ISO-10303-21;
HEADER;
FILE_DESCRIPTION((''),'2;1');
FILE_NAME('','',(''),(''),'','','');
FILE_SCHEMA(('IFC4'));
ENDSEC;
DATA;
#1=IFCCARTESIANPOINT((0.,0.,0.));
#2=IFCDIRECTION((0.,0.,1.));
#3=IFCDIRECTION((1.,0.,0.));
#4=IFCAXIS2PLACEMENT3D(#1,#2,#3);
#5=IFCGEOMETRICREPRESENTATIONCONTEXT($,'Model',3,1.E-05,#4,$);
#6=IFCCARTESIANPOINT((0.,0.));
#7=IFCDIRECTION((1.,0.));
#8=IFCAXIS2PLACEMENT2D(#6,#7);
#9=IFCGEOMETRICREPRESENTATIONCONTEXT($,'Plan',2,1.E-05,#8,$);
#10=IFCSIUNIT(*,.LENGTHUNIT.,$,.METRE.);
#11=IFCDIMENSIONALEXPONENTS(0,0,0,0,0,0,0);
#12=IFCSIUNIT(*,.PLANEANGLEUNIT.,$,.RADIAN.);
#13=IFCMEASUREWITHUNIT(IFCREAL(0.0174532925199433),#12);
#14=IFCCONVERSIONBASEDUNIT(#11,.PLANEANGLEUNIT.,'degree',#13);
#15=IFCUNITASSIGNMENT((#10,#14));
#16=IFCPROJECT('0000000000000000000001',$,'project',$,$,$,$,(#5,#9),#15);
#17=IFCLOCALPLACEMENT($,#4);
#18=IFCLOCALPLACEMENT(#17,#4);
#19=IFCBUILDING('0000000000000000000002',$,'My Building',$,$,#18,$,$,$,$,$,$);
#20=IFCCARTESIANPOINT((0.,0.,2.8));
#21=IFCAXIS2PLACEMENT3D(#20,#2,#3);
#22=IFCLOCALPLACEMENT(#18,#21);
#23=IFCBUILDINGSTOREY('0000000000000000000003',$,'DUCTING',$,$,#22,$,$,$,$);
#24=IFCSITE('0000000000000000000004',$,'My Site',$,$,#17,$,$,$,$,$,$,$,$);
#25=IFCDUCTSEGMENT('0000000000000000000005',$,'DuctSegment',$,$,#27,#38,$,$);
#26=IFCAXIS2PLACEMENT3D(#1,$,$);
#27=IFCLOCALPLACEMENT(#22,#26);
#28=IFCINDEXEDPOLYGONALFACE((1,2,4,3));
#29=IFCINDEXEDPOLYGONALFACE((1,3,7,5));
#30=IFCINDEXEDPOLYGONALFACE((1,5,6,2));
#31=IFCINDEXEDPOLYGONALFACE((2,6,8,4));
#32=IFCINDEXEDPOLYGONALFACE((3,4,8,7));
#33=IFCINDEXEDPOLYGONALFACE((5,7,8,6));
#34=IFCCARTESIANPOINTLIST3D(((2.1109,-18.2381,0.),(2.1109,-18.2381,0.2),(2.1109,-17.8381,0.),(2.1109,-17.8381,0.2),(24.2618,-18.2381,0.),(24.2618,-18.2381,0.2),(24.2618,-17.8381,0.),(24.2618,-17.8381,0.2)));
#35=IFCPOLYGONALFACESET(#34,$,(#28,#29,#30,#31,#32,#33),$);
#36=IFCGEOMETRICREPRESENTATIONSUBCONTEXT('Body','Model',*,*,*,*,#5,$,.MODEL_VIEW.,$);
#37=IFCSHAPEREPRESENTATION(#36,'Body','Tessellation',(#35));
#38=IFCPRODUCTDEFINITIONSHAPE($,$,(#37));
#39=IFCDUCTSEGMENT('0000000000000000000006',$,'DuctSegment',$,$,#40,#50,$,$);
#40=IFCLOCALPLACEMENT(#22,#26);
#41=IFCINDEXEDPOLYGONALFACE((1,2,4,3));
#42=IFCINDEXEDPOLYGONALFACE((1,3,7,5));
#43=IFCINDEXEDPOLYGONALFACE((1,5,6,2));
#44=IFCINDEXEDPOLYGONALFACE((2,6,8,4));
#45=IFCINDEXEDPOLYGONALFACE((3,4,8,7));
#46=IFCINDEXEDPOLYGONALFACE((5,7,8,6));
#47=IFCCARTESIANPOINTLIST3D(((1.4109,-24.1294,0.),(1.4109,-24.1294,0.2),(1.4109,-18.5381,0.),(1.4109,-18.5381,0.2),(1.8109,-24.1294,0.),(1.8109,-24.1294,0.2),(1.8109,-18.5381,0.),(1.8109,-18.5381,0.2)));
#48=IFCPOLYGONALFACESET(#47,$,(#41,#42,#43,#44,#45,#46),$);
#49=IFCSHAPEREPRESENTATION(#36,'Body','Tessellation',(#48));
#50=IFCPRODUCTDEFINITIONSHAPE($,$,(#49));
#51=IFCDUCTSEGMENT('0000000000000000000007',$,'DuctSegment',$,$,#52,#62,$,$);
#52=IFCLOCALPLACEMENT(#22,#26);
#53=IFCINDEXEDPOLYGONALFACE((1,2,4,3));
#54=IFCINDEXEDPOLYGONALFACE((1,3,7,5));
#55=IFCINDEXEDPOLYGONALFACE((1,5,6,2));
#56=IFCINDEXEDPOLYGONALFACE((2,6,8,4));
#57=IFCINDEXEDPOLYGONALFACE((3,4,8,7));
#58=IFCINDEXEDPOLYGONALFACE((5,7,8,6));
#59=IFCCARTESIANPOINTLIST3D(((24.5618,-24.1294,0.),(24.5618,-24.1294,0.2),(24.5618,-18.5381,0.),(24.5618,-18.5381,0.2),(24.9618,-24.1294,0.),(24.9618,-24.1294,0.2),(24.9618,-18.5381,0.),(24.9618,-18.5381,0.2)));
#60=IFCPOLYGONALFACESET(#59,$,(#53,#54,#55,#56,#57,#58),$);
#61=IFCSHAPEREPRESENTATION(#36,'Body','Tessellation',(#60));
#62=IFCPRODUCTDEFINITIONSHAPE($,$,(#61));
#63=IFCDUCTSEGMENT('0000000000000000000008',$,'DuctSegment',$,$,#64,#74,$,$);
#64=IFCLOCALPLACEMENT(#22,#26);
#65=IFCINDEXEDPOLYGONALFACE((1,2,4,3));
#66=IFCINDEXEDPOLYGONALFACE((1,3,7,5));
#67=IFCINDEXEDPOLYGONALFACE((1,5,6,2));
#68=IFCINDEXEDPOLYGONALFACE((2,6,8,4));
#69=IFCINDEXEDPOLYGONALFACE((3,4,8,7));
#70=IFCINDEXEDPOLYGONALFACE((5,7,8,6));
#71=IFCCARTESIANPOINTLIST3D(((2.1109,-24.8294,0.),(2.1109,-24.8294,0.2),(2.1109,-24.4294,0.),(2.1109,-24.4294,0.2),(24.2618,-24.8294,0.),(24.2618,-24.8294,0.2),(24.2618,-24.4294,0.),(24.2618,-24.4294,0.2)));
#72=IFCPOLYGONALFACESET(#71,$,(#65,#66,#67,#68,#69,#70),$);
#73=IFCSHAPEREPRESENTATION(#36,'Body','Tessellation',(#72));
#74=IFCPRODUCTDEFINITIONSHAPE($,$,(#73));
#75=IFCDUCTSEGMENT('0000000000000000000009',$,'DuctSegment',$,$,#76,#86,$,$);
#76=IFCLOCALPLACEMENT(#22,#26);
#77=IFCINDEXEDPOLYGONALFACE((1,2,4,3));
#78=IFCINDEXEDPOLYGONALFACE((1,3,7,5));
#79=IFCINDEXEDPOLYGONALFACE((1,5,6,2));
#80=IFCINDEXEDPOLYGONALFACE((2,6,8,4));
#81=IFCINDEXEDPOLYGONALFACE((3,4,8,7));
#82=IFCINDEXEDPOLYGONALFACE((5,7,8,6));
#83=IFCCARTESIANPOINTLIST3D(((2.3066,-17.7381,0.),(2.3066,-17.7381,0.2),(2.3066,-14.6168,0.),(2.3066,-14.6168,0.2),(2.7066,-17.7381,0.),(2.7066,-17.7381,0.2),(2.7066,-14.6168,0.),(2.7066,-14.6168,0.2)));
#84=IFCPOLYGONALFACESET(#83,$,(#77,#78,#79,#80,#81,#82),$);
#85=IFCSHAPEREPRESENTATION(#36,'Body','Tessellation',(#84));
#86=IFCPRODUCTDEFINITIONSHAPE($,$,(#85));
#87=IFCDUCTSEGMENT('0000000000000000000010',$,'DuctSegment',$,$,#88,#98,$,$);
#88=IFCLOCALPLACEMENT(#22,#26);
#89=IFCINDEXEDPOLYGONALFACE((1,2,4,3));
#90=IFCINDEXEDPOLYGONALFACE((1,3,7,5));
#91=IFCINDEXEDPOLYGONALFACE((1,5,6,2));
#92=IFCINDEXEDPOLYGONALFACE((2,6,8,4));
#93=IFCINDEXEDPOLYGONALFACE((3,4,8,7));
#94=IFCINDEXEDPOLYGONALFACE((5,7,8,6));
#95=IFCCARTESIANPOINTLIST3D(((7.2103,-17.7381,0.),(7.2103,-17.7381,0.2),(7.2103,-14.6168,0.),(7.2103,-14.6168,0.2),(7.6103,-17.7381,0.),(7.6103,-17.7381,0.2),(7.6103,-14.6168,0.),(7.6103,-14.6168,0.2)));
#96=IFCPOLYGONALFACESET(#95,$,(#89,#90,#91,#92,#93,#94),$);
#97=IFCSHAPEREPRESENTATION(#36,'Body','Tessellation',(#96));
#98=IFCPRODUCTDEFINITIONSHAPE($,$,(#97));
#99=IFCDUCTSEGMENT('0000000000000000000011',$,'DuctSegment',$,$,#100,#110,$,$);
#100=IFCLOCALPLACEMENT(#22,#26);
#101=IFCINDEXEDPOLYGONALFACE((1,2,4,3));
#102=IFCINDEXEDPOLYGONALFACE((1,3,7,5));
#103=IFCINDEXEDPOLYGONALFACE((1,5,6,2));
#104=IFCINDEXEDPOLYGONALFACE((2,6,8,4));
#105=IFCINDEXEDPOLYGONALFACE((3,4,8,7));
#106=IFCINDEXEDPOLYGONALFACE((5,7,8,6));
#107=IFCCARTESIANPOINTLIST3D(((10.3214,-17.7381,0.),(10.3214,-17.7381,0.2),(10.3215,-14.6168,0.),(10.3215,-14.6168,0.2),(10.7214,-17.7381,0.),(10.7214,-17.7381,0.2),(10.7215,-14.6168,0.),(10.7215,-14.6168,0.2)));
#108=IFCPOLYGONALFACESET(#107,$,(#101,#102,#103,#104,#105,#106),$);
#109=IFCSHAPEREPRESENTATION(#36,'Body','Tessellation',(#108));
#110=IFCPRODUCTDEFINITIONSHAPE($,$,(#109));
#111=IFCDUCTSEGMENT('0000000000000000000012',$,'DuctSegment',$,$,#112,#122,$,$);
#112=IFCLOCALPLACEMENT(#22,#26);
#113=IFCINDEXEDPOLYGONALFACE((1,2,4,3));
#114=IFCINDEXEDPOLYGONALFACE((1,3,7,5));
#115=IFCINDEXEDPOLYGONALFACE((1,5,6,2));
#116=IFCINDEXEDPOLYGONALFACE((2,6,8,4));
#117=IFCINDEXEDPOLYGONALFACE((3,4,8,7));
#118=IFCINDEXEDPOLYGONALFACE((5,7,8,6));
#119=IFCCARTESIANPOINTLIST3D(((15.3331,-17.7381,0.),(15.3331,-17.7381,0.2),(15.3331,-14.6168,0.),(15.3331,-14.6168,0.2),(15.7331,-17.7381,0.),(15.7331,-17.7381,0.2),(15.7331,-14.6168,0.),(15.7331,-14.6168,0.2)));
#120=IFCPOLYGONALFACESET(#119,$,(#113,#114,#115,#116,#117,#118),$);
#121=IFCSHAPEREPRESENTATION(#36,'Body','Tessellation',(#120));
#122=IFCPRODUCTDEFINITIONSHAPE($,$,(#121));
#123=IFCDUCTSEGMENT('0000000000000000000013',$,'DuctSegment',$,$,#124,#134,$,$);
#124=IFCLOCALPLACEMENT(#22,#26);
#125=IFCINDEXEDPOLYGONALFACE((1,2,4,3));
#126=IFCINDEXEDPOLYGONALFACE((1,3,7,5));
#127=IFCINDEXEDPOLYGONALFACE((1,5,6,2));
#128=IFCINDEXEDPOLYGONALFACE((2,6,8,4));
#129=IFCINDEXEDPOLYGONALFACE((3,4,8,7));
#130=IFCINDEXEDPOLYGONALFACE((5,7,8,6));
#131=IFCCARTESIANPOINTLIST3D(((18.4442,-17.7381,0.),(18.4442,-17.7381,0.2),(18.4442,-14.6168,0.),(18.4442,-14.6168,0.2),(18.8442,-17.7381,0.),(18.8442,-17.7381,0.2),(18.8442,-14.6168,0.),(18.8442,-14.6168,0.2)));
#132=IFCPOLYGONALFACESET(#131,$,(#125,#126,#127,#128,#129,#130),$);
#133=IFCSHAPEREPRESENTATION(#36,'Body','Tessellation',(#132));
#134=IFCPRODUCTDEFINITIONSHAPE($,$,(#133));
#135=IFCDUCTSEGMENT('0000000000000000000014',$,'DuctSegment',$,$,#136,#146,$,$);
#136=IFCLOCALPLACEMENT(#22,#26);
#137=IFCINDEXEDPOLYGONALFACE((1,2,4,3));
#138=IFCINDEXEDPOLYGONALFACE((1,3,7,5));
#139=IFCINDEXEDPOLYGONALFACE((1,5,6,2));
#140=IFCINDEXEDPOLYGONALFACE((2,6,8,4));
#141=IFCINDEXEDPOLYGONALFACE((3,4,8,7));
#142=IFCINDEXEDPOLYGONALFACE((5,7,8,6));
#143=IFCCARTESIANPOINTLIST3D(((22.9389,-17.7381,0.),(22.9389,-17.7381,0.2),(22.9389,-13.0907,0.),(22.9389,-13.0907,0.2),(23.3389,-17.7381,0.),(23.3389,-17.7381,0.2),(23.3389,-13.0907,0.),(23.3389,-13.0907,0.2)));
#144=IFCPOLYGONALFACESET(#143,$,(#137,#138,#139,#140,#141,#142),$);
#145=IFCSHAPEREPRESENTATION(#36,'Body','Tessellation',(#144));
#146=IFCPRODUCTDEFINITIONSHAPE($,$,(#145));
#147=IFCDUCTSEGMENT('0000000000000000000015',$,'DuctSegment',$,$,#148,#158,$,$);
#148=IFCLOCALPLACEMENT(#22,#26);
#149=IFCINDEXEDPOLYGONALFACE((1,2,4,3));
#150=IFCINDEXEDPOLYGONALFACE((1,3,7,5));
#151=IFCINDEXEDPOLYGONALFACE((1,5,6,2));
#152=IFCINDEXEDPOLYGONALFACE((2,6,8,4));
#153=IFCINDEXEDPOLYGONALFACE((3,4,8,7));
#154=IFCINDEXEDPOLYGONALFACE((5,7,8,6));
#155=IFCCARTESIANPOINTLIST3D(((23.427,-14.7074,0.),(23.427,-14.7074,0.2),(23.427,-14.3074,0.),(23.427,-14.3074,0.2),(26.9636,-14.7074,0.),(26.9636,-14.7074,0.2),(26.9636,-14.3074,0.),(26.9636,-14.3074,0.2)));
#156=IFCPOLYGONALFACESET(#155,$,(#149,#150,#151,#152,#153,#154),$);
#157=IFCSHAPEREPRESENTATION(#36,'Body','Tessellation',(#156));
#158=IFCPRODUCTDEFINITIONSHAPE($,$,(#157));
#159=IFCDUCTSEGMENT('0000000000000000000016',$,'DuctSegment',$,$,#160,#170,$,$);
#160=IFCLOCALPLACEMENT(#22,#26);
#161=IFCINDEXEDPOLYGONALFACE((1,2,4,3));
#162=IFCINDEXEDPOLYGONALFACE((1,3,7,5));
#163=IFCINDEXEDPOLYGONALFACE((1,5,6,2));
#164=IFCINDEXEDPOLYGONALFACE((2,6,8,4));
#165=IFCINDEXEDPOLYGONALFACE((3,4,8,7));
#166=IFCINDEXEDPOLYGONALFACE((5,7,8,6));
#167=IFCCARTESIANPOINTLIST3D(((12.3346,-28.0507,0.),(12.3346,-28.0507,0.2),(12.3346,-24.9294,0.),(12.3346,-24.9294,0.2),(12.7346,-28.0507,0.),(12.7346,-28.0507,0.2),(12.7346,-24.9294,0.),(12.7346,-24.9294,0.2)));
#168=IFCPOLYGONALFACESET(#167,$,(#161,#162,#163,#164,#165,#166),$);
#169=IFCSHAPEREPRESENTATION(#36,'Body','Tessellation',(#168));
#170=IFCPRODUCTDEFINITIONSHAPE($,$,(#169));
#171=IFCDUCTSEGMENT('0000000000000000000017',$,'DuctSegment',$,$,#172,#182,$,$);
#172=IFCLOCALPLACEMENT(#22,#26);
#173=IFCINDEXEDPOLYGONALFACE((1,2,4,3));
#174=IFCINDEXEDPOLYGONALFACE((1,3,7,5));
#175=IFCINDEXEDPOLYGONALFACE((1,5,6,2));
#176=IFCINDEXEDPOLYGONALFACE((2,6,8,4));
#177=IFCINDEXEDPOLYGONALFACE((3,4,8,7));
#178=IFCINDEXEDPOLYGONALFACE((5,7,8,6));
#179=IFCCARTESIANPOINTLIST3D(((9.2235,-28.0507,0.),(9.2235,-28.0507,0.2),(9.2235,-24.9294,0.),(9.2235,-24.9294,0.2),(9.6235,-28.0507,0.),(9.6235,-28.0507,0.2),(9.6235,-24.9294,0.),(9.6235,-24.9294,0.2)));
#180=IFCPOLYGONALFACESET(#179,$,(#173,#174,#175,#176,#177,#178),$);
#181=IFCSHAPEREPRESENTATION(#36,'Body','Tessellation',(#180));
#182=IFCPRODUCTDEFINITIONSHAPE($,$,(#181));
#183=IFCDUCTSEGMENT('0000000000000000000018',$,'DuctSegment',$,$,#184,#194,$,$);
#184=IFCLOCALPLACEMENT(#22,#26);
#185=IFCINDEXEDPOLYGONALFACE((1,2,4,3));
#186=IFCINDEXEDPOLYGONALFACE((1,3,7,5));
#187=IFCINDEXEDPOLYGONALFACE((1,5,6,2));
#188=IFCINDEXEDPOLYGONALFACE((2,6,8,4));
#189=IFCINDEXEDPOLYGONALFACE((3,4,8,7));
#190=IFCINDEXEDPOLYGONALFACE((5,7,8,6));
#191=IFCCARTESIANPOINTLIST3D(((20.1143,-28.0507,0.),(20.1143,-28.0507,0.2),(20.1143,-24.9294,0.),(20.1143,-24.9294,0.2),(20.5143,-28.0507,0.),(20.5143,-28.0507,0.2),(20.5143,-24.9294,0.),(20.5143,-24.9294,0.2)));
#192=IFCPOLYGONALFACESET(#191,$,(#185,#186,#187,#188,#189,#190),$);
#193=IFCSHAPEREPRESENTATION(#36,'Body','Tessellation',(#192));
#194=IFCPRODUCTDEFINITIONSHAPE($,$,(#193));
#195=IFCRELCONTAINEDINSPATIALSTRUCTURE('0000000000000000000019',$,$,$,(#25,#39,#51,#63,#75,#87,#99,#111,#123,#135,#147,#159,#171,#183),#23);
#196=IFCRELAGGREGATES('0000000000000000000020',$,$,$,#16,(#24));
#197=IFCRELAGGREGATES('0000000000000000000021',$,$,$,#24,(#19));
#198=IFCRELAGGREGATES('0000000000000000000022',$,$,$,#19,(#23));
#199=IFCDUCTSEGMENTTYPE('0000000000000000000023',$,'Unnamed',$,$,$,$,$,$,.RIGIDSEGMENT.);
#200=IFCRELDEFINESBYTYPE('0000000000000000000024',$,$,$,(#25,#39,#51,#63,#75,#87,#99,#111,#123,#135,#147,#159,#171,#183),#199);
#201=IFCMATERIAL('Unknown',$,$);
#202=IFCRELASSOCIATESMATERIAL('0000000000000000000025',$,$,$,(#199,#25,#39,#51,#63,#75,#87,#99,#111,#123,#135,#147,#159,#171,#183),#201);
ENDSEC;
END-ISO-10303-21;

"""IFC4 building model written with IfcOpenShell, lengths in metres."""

from ifc_helpers import new_model, entity, si_unit, converted_unit, frame, origin_with_axes, origin_2d_with_axis, place, context, subcontext, project, spatial, rectangle, extrude, material, material_profile, profile_set, profile_usage, type_object, element, save


model = new_model("IFC4")

# Units and contexts
model_context = context("Model", 3, precision=1e-05, world=origin_with_axes())
plan_context = context("Plan", 2, precision=1e-05, world=origin_2d_with_axis())
body_context = subcontext(model_context, "Body", "Model", "MODEL_VIEW")
ifc_project = project(units=[si_unit("LENGTHUNIT", "METRE"), converted_unit("PLANEANGLEUNIT", "degree", entity("IfcReal", 0.0174532925199433), si_unit("PLANEANGLEUNIT", "RADIAN"), dimensions=[0, 0, 0, 0, 0, 0, 0])], contexts=[model_context, plan_context])

# Site, building, storey
site_placement = place(None, origin_with_axes())
site = spatial("IfcSite", under=ifc_project, at=site_placement, Name="My Site")
building_placement = place(site_placement, origin_with_axes())
building = spatial("IfcBuilding", under=site, at=building_placement, Name="My Building")
storey_placement = place(building_placement, frame((0.0, 0.0, 2.8), z_axis=(0.0, 0.0, 1.0), x_axis=(1.0, 0.0, 0.0)))
storey = spatial("IfcBuildingStorey", under=building, at=storey_placement, Name="DUCTING")

# Duct segments
ifc_material = material(Name="Unknown")
ifc_material_profile_1 = material_profile(ifc_material, rectangle(XDim=0.4, YDim=0.2))
ifc_profile_set_1 = profile_set([ifc_material_profile_1])
ifc_profile_usage_1 = profile_usage(ifc_profile_set_1, cardinal=5)
duct_segment_type = type_object("IfcDuctSegmentType", Name="Unnamed", PredefinedType="RIGIDSEGMENT", material=ifc_profile_set_1)
duct_segment_1_placement = place(storey_placement, frame((2.1109, -18.0381, 0.1), z_axis=(1.0, 0.0, 0.0), x_axis=(0.0, 1.0, 0.0)))
element("IfcDuctSegment", 1, at=duct_segment_1_placement, inside=storey, type_object=duct_segment_type, material=ifc_profile_usage_1, Name="DuctSegment", context=body_context, shape_type="SweptSolid", body=[
    extrude(rectangle(XDim=0.4, YDim=0.2), origin_with_axes(), (0.0, 0.0, 1.0), 22.1508),
])
ifc_profile_usage_2 = profile_usage(ifc_profile_set_1, cardinal=5)
duct_segment_2_placement = place(storey_placement, frame((1.6109, -18.5381, 0.1), z_axis=(0.0, -1.0, 0.0), x_axis=(1.0, 0.0, 0.0)))
element("IfcDuctSegment", 2, at=duct_segment_2_placement, inside=storey, type_object=duct_segment_type, material=ifc_profile_usage_2, Name="DuctSegment", context=body_context, shape_type="SweptSolid", body=[
    extrude(rectangle(XDim=0.4, YDim=0.2), origin_with_axes(), (0.0, 0.0, 1.0), 5.5913),
])
ifc_profile_usage_3 = profile_usage(ifc_profile_set_1, cardinal=5)
duct_segment_3_placement = place(storey_placement, frame((24.7618, -18.5381, 0.1), z_axis=(0.0, -1.0, 0.0), x_axis=(1.0, 0.0, 0.0)))
element("IfcDuctSegment", 3, at=duct_segment_3_placement, inside=storey, type_object=duct_segment_type, material=ifc_profile_usage_3, Name="DuctSegment", context=body_context, shape_type="SweptSolid", body=[
    extrude(rectangle(XDim=0.4, YDim=0.2), origin_with_axes(), (0.0, 0.0, 1.0), 5.5913),
])
ifc_profile_usage_4 = profile_usage(ifc_profile_set_1, cardinal=5)
duct_segment_4_placement = place(storey_placement, frame((2.1109, -24.6294, 0.1), z_axis=(1.0, 0.0, 0.0), x_axis=(0.0, 1.0, 0.0)))
element("IfcDuctSegment", 4, at=duct_segment_4_placement, inside=storey, type_object=duct_segment_type, material=ifc_profile_usage_4, Name="DuctSegment", context=body_context, shape_type="SweptSolid", body=[
    extrude(rectangle(XDim=0.4, YDim=0.2), origin_with_axes(), (0.0, 0.0, 1.0), 22.1508),
])
ifc_profile_usage_5 = profile_usage(ifc_profile_set_1, cardinal=5)
duct_segment_5_placement = place(storey_placement, frame((2.5066, -14.6168, 0.1), z_axis=(0.0, -1.0, 0.0), x_axis=(-1.0, 0.0, 0.0)))
element("IfcDuctSegment", 5, at=duct_segment_5_placement, inside=storey, type_object=duct_segment_type, material=ifc_profile_usage_5, Name="DuctSegment", context=body_context, shape_type="SweptSolid", body=[
    extrude(rectangle(XDim=0.4, YDim=0.2), origin_with_axes(), (0.0, 0.0, 1.0), 3.1213),
])
ifc_profile_usage_6 = profile_usage(ifc_profile_set_1, cardinal=5)
duct_segment_6_placement = place(storey_placement, frame((7.4103, -14.6168, 0.1), z_axis=(0.0, -1.0, 0.0), x_axis=(1.0, 0.0, 0.0)))
element("IfcDuctSegment", 6, at=duct_segment_6_placement, inside=storey, type_object=duct_segment_type, material=ifc_profile_usage_6, Name="DuctSegment", context=body_context, shape_type="SweptSolid", body=[
    extrude(rectangle(XDim=0.4, YDim=0.2), origin_with_axes(), (0.0, 0.0, 1.0), 3.1213),
])
ifc_profile_usage_7 = profile_usage(ifc_profile_set_1, cardinal=5)
duct_segment_7_placement = place(storey_placement, frame((10.5214, -17.7381, 0.1), z_axis=(0.000001, 1.0, 0.0), x_axis=(-1.0, 0.000001, 0.0)))
element("IfcDuctSegment", 7, at=duct_segment_7_placement, inside=storey, type_object=duct_segment_type, material=ifc_profile_usage_7, Name="DuctSegment", context=body_context, shape_type="SweptSolid", body=[
    extrude(rectangle(XDim=0.4, YDim=0.2), origin_with_axes(), (0.0, 0.0, 1.0), 3.1213),
])
ifc_profile_usage_8 = profile_usage(ifc_profile_set_1, cardinal=5)
duct_segment_8_placement = place(storey_placement, frame((15.5331, -14.6168, 0.1), z_axis=(0.0, -1.0, 0.0), x_axis=(1.0, 0.0, 0.0)))
element("IfcDuctSegment", 8, at=duct_segment_8_placement, inside=storey, type_object=duct_segment_type, material=ifc_profile_usage_8, Name="DuctSegment", context=body_context, shape_type="SweptSolid", body=[
    extrude(rectangle(XDim=0.4, YDim=0.2), origin_with_axes(), (0.0, 0.0, 1.0), 3.1213),
])
ifc_profile_usage_9 = profile_usage(ifc_profile_set_1, cardinal=5)
duct_segment_9_placement = place(storey_placement, frame((18.6442, -14.6168, 0.1), z_axis=(0.0, -1.0, 0.0), x_axis=(1.0, 0.0, 0.0)))
element("IfcDuctSegment", 9, at=duct_segment_9_placement, inside=storey, type_object=duct_segment_type, material=ifc_profile_usage_9, Name="DuctSegment", context=body_context, shape_type="SweptSolid", body=[
    extrude(rectangle(XDim=0.4, YDim=0.2), origin_with_axes(), (0.0, 0.0, 1.0), 3.1213),
])
ifc_profile_usage_10 = profile_usage(ifc_profile_set_1, cardinal=5)
duct_segment_10_placement = place(storey_placement, frame((23.1389, -13.0907, 0.1), z_axis=(0.0, -1.0, 0.0), x_axis=(1.0, 0.0, 0.0)))
element("IfcDuctSegment", 10, at=duct_segment_10_placement, inside=storey, type_object=duct_segment_type, material=ifc_profile_usage_10, Name="DuctSegment", context=body_context, shape_type="SweptSolid", body=[
    extrude(rectangle(XDim=0.4, YDim=0.2), origin_with_axes(), (0.0, 0.0, 1.0), 4.6473),
])
ifc_profile_usage_11 = profile_usage(ifc_profile_set_1, cardinal=5)
duct_segment_11_placement = place(storey_placement, frame((23.427, -14.5074, 0.1), z_axis=(1.0, 0.0, 0.0), x_axis=(0.0, 1.0, 0.0)))
element("IfcDuctSegment", 11, at=duct_segment_11_placement, inside=storey, type_object=duct_segment_type, material=ifc_profile_usage_11, Name="DuctSegment", context=body_context, shape_type="SweptSolid", body=[
    extrude(rectangle(XDim=0.4, YDim=0.2), origin_with_axes(), (0.0, 0.0, 1.0), 3.5366),
])
ifc_profile_usage_12 = profile_usage(ifc_profile_set_1, cardinal=5)
duct_segment_12_placement = place(storey_placement, frame((12.5346, -24.9294, 0.1), z_axis=(0.0, -1.0, 0.0), x_axis=(1.0, 0.0, 0.0)))
element("IfcDuctSegment", 12, at=duct_segment_12_placement, inside=storey, type_object=duct_segment_type, material=ifc_profile_usage_12, Name="DuctSegment", context=body_context, shape_type="SweptSolid", body=[
    extrude(rectangle(XDim=0.4, YDim=0.2), origin_with_axes(), (0.0, 0.0, 1.0), 3.1213),
])
ifc_profile_usage_13 = profile_usage(ifc_profile_set_1, cardinal=5)
duct_segment_13_placement = place(storey_placement, frame((9.4235, -24.9294, 0.1), z_axis=(0.0, -1.0, 0.0), x_axis=(1.0, 0.0, 0.0)))
element("IfcDuctSegment", 13, at=duct_segment_13_placement, inside=storey, type_object=duct_segment_type, material=ifc_profile_usage_13, Name="DuctSegment", context=body_context, shape_type="SweptSolid", body=[
    extrude(rectangle(XDim=0.4, YDim=0.2), origin_with_axes(), (0.0, 0.0, 1.0), 3.1213),
])
ifc_profile_usage_14 = profile_usage(ifc_profile_set_1, cardinal=5)
duct_segment_14_placement = place(storey_placement, frame((20.3143, -24.9294, 0.1), z_axis=(0.0, -1.0, 0.0), x_axis=(1.0, 0.0, 0.0)))
element("IfcDuctSegment", 14, at=duct_segment_14_placement, inside=storey, type_object=duct_segment_type, material=ifc_profile_usage_14, Name="DuctSegment", context=body_context, shape_type="SweptSolid", body=[
    extrude(rectangle(XDim=0.4, YDim=0.2), origin_with_axes(), (0.0, 0.0, 1.0), 3.1213),
])

save(model, "model.ifc")
